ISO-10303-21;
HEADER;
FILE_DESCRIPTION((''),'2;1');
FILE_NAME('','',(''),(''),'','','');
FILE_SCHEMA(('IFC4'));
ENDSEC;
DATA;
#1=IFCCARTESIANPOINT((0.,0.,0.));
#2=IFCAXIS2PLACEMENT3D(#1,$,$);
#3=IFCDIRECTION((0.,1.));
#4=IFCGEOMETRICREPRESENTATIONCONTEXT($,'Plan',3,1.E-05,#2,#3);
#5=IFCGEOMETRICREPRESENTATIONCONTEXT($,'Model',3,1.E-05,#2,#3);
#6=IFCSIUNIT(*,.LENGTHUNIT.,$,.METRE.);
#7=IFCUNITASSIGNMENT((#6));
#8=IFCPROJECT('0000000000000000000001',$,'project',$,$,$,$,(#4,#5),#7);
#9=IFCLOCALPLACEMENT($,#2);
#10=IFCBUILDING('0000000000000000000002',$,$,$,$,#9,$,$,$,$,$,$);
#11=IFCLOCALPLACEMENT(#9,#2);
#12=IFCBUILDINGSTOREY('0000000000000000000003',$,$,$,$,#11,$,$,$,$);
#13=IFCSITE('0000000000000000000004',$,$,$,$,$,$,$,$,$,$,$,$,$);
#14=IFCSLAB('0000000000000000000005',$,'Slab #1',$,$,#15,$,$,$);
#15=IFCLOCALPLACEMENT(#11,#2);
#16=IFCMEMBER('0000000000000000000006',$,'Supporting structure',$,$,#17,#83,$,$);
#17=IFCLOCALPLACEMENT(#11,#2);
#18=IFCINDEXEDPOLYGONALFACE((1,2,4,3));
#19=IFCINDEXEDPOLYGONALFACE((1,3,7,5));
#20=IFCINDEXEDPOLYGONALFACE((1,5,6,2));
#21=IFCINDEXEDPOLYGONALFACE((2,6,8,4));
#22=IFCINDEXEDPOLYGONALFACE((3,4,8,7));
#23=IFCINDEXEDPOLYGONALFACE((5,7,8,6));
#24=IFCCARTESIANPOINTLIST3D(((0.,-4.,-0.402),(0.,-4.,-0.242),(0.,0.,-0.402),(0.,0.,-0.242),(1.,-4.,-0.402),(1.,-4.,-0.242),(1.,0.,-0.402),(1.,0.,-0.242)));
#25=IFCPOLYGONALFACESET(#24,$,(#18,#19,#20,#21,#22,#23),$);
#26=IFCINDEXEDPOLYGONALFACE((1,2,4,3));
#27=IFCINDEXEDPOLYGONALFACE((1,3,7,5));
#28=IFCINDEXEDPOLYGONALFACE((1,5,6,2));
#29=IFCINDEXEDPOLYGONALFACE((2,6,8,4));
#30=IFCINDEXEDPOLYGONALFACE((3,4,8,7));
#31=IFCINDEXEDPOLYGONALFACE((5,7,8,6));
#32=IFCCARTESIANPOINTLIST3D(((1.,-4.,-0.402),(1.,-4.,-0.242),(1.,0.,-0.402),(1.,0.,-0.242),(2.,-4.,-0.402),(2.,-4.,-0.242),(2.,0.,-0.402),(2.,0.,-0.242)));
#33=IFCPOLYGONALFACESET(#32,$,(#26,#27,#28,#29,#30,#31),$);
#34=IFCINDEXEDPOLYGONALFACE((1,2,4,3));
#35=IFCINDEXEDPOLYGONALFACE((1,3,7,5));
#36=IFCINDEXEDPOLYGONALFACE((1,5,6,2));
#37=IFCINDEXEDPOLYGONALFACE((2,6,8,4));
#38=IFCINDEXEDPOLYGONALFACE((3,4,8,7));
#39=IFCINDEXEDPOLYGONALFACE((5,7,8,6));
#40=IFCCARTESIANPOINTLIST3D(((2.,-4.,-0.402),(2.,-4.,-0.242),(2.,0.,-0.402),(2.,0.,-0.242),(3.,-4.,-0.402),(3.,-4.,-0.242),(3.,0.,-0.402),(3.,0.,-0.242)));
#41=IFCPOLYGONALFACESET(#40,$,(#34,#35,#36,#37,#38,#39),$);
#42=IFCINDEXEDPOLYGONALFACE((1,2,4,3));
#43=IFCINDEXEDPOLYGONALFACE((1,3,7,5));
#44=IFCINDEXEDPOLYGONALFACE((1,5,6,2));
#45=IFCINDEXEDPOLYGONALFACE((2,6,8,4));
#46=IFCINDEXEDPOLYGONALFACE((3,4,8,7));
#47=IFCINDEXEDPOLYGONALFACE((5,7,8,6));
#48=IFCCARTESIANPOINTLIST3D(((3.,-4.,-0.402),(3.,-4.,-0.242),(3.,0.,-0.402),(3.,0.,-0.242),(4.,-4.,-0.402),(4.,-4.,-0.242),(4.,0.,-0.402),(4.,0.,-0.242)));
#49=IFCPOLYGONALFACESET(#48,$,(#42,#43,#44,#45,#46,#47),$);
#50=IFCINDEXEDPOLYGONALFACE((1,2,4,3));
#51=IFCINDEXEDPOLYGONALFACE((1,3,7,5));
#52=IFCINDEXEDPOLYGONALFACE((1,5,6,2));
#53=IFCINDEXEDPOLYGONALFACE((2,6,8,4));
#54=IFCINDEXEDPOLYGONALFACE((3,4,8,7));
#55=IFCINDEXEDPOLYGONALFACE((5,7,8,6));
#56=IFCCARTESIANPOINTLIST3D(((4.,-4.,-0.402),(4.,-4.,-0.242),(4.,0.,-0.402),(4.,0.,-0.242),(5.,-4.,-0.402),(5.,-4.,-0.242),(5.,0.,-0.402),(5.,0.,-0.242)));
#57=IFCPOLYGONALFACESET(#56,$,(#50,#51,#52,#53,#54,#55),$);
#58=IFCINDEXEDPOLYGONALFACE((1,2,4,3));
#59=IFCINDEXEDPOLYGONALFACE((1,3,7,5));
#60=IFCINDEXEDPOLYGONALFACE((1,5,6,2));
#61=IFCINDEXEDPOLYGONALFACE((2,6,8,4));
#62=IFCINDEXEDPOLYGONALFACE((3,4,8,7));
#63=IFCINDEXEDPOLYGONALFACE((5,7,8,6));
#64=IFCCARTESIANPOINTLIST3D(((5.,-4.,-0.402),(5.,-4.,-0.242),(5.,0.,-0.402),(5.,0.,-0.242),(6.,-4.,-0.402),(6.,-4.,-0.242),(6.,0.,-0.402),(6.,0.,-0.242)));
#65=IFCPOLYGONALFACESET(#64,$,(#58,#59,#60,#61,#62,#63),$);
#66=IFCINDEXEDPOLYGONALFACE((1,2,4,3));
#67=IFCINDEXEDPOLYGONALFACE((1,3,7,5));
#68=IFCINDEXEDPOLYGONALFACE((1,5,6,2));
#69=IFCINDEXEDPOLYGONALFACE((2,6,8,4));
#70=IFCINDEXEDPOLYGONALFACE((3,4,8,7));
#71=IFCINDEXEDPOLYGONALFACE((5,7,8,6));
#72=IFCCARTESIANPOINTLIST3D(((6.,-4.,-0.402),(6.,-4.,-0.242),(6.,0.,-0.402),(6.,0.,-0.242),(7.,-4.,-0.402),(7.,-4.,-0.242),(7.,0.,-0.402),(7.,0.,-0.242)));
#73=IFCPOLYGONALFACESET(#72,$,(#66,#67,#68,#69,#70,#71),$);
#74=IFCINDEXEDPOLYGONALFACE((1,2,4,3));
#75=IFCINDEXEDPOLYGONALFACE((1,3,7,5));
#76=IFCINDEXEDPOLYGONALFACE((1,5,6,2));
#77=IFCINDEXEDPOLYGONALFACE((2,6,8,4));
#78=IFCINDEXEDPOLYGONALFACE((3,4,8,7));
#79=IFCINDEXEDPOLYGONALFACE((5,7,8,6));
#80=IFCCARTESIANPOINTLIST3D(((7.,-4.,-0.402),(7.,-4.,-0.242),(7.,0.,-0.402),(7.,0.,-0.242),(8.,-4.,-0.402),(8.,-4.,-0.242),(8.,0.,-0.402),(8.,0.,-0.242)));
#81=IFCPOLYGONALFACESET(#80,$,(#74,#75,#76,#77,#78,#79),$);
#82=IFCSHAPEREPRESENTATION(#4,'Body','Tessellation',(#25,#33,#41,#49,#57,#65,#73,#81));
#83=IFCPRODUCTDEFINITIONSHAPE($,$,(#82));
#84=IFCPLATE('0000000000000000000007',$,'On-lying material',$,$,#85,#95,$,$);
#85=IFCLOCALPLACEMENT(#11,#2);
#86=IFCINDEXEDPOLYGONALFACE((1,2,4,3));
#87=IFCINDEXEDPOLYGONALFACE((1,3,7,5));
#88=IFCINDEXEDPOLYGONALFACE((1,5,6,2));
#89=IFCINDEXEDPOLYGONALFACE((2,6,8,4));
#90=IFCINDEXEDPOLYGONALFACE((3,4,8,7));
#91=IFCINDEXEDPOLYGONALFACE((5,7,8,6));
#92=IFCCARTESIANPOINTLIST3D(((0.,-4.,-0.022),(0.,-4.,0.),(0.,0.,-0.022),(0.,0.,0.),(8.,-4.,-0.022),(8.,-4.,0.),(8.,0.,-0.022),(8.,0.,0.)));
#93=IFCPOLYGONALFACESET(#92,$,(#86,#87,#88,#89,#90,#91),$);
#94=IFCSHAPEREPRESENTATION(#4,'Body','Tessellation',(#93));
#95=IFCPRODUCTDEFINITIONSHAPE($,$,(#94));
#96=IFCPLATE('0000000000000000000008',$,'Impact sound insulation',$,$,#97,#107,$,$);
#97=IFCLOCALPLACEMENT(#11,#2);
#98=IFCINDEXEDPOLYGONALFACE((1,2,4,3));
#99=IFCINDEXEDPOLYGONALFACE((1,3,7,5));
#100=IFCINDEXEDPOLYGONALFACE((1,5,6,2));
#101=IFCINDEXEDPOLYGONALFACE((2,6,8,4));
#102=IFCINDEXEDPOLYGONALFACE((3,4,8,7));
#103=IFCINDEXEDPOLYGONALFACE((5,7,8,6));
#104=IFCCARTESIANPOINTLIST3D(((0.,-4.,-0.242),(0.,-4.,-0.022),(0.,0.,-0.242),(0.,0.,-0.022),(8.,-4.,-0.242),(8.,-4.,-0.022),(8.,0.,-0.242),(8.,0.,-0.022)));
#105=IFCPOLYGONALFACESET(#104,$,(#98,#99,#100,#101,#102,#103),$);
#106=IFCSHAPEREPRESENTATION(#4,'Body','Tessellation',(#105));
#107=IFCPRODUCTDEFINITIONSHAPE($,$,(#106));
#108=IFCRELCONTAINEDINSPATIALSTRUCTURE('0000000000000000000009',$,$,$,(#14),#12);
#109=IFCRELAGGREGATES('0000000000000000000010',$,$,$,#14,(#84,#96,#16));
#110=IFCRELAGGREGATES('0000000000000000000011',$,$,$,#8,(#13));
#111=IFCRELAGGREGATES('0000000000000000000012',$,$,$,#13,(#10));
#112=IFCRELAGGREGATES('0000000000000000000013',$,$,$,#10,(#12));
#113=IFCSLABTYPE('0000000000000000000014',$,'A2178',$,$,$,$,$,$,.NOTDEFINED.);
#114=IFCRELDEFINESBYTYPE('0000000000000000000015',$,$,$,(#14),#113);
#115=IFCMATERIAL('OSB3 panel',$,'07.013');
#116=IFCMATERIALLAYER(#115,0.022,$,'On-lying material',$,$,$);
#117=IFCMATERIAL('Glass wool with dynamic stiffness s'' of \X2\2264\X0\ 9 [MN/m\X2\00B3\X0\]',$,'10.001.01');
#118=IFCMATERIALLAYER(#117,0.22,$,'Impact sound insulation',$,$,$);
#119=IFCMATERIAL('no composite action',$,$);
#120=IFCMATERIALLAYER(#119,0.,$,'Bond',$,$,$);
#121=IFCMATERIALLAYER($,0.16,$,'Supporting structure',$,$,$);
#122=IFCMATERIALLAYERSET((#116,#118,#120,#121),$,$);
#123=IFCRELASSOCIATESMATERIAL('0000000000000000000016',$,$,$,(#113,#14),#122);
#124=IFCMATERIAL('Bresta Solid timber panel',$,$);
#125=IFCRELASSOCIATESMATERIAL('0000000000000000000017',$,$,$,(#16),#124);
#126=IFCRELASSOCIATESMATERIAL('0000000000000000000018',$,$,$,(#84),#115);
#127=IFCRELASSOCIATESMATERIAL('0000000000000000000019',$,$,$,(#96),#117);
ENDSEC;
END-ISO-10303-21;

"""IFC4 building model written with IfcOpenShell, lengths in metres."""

from ifc_helpers import new_model, si_unit, direction, frame, frame_2d, origin, origin_with_axes, place, context, project, spatial, rectangle, extrude, material, layer, layer_set, type_object, element, aggregate, save


model = new_model("IFC4")

# Units and contexts
plan_context = context("Plan", 3, precision=1e-05, world=origin(), true_north=direction((0.0, 1.0)))
model_context = context("Model", 3, precision=1e-05, world=origin(), true_north=direction((0.0, 1.0)))
ifc_project = project(units=[si_unit("LENGTHUNIT", "METRE")], contexts=[plan_context, model_context])

# Site, building, storey
site = spatial("IfcSite", under=ifc_project)
building_placement = place(None, origin())
building = spatial("IfcBuilding", under=site, at=building_placement)
storey_placement = place(building_placement, origin())
storey = spatial("IfcBuildingStorey", under=building, at=storey_placement)

# Slab, member, plates
ifc_material_1 = material(Name="OSB3 panel", Category="07.013")
ifc_layer_1 = layer(ifc_material_1, 0.022, Name="On-lying material")
ifc_material_2 = material(Name="Glass wool with dynamic stiffness s' of ≤ 9 [MN/m³]", Category="10.001.01")
ifc_layer_2 = layer(ifc_material_2, 0.22, Name="Impact sound insulation")
ifc_material_3 = material(Name="no composite action")
ifc_layer_3 = layer(ifc_material_3, 0.0, Name="Bond")
ifc_layer_4 = layer(None, 0.16, Name="Supporting structure")
ifc_layer_set = layer_set([ifc_layer_1, ifc_layer_2, ifc_layer_3, ifc_layer_4])
slab_type = type_object("IfcSlabType", Name="A2178", PredefinedType="NOTDEFINED", material=ifc_layer_set)
slab_placement = place(None, frame((0.0, 0.0, 0.0), z_axis=(0.0, 0.0, -1.0), x_axis=(1.0, 0.0, 0.0)))
slab = element("IfcSlab", 1, at=slab_placement, inside=storey, type_object=slab_type, material=ifc_layer_set, Name="Slab #1")
ifc_material_4 = material(Name="Bresta Solid timber panel")
member_placement = place(slab_placement, origin())
member = element("IfcMember", 2, at=member_placement, material=ifc_material_4, Name="Supporting structure", context=plan_context, shape_type="SweptSolid", body=[
    extrude(rectangle(XDim=1.0, YDim=0.16, at=frame_2d((0.5, 0.08), x_axis=(1.0, 0.0))), frame((0.0, 4.0, 0.242), z_axis=(0.0, -1.0, 0.0), x_axis=(1.0, 0.0, 0.0)), (0.0, 0.0, 1.0), 4.0),
    extrude(rectangle(XDim=1.0, YDim=0.16, at=frame_2d((0.5, 0.08), x_axis=(1.0, 0.0))), frame((1.0, 4.0, 0.242), z_axis=(0.0, -1.0, 0.0), x_axis=(1.0, 0.0, 0.0)), (0.0, 0.0, 1.0), 4.0),
    extrude(rectangle(XDim=1.0, YDim=0.16, at=frame_2d((0.5, 0.08), x_axis=(1.0, 0.0))), frame((2.0, 4.0, 0.242), z_axis=(0.0, -1.0, 0.0), x_axis=(1.0, 0.0, 0.0)), (0.0, 0.0, 1.0), 4.0),
    extrude(rectangle(XDim=1.0, YDim=0.16, at=frame_2d((0.5, 0.08), x_axis=(1.0, 0.0))), frame((3.0, 4.0, 0.242), z_axis=(0.0, -1.0, 0.0), x_axis=(1.0, 0.0, 0.0)), (0.0, 0.0, 1.0), 4.0),
    extrude(rectangle(XDim=1.0, YDim=0.16, at=frame_2d((0.5, 0.08), x_axis=(1.0, 0.0))), frame((4.0, 4.0, 0.242), z_axis=(0.0, -1.0, 0.0), x_axis=(1.0, 0.0, 0.0)), (0.0, 0.0, 1.0), 4.0),
    extrude(rectangle(XDim=1.0, YDim=0.16, at=frame_2d((0.5, 0.08), x_axis=(1.0, 0.0))), frame((5.0, 4.0, 0.242), z_axis=(0.0, -1.0, 0.0), x_axis=(1.0, 0.0, 0.0)), (0.0, 0.0, 1.0), 4.0),
    extrude(rectangle(XDim=1.0, YDim=0.16, at=frame_2d((0.5, 0.08), x_axis=(1.0, 0.0))), frame((6.0, 4.0, 0.242), z_axis=(0.0, -1.0, 0.0), x_axis=(1.0, 0.0, 0.0)), (0.0, 0.0, 1.0), 4.0),
    extrude(rectangle(XDim=1.0, YDim=0.16, at=frame_2d((0.5, 0.08), x_axis=(1.0, 0.0))), frame((7.0, 4.0, 0.242), z_axis=(0.0, -1.0, 0.0), x_axis=(1.0, 0.0, 0.0)), (0.0, 0.0, 1.0), 4.0),
])
plate_1_placement = place(slab_placement, origin())
plate_1 = element("IfcPlate", 3, at=plate_1_placement, material=ifc_material_1, Name="On-lying material", context=plan_context, shape_type="SweptSolid", body=[
    extrude(rectangle(XDim=8.0, YDim=4.0, at=frame_2d((4.0, 2.0), x_axis=(1.0, 0.0))), origin_with_axes(), (0.0, 0.0, 1.0), 0.022),
])
plate_2_placement = place(slab_placement, origin())
plate_2 = element("IfcPlate", 4, at=plate_2_placement, material=ifc_material_2, Name="Impact sound insulation", context=plan_context, shape_type="SweptSolid", body=[
    extrude(rectangle(XDim=8.0, YDim=4.0, at=frame_2d((4.0, 2.0), x_axis=(1.0, 0.0))), frame((0.0, 0.0, 0.022), z_axis=(0.0, 0.0, 1.0), x_axis=(1.0, 0.0, 0.0)), (0.0, 0.0, 1.0), 0.22),
])
aggregate(slab, [plate_1, plate_2, member])

save(model, "model.ifc")
